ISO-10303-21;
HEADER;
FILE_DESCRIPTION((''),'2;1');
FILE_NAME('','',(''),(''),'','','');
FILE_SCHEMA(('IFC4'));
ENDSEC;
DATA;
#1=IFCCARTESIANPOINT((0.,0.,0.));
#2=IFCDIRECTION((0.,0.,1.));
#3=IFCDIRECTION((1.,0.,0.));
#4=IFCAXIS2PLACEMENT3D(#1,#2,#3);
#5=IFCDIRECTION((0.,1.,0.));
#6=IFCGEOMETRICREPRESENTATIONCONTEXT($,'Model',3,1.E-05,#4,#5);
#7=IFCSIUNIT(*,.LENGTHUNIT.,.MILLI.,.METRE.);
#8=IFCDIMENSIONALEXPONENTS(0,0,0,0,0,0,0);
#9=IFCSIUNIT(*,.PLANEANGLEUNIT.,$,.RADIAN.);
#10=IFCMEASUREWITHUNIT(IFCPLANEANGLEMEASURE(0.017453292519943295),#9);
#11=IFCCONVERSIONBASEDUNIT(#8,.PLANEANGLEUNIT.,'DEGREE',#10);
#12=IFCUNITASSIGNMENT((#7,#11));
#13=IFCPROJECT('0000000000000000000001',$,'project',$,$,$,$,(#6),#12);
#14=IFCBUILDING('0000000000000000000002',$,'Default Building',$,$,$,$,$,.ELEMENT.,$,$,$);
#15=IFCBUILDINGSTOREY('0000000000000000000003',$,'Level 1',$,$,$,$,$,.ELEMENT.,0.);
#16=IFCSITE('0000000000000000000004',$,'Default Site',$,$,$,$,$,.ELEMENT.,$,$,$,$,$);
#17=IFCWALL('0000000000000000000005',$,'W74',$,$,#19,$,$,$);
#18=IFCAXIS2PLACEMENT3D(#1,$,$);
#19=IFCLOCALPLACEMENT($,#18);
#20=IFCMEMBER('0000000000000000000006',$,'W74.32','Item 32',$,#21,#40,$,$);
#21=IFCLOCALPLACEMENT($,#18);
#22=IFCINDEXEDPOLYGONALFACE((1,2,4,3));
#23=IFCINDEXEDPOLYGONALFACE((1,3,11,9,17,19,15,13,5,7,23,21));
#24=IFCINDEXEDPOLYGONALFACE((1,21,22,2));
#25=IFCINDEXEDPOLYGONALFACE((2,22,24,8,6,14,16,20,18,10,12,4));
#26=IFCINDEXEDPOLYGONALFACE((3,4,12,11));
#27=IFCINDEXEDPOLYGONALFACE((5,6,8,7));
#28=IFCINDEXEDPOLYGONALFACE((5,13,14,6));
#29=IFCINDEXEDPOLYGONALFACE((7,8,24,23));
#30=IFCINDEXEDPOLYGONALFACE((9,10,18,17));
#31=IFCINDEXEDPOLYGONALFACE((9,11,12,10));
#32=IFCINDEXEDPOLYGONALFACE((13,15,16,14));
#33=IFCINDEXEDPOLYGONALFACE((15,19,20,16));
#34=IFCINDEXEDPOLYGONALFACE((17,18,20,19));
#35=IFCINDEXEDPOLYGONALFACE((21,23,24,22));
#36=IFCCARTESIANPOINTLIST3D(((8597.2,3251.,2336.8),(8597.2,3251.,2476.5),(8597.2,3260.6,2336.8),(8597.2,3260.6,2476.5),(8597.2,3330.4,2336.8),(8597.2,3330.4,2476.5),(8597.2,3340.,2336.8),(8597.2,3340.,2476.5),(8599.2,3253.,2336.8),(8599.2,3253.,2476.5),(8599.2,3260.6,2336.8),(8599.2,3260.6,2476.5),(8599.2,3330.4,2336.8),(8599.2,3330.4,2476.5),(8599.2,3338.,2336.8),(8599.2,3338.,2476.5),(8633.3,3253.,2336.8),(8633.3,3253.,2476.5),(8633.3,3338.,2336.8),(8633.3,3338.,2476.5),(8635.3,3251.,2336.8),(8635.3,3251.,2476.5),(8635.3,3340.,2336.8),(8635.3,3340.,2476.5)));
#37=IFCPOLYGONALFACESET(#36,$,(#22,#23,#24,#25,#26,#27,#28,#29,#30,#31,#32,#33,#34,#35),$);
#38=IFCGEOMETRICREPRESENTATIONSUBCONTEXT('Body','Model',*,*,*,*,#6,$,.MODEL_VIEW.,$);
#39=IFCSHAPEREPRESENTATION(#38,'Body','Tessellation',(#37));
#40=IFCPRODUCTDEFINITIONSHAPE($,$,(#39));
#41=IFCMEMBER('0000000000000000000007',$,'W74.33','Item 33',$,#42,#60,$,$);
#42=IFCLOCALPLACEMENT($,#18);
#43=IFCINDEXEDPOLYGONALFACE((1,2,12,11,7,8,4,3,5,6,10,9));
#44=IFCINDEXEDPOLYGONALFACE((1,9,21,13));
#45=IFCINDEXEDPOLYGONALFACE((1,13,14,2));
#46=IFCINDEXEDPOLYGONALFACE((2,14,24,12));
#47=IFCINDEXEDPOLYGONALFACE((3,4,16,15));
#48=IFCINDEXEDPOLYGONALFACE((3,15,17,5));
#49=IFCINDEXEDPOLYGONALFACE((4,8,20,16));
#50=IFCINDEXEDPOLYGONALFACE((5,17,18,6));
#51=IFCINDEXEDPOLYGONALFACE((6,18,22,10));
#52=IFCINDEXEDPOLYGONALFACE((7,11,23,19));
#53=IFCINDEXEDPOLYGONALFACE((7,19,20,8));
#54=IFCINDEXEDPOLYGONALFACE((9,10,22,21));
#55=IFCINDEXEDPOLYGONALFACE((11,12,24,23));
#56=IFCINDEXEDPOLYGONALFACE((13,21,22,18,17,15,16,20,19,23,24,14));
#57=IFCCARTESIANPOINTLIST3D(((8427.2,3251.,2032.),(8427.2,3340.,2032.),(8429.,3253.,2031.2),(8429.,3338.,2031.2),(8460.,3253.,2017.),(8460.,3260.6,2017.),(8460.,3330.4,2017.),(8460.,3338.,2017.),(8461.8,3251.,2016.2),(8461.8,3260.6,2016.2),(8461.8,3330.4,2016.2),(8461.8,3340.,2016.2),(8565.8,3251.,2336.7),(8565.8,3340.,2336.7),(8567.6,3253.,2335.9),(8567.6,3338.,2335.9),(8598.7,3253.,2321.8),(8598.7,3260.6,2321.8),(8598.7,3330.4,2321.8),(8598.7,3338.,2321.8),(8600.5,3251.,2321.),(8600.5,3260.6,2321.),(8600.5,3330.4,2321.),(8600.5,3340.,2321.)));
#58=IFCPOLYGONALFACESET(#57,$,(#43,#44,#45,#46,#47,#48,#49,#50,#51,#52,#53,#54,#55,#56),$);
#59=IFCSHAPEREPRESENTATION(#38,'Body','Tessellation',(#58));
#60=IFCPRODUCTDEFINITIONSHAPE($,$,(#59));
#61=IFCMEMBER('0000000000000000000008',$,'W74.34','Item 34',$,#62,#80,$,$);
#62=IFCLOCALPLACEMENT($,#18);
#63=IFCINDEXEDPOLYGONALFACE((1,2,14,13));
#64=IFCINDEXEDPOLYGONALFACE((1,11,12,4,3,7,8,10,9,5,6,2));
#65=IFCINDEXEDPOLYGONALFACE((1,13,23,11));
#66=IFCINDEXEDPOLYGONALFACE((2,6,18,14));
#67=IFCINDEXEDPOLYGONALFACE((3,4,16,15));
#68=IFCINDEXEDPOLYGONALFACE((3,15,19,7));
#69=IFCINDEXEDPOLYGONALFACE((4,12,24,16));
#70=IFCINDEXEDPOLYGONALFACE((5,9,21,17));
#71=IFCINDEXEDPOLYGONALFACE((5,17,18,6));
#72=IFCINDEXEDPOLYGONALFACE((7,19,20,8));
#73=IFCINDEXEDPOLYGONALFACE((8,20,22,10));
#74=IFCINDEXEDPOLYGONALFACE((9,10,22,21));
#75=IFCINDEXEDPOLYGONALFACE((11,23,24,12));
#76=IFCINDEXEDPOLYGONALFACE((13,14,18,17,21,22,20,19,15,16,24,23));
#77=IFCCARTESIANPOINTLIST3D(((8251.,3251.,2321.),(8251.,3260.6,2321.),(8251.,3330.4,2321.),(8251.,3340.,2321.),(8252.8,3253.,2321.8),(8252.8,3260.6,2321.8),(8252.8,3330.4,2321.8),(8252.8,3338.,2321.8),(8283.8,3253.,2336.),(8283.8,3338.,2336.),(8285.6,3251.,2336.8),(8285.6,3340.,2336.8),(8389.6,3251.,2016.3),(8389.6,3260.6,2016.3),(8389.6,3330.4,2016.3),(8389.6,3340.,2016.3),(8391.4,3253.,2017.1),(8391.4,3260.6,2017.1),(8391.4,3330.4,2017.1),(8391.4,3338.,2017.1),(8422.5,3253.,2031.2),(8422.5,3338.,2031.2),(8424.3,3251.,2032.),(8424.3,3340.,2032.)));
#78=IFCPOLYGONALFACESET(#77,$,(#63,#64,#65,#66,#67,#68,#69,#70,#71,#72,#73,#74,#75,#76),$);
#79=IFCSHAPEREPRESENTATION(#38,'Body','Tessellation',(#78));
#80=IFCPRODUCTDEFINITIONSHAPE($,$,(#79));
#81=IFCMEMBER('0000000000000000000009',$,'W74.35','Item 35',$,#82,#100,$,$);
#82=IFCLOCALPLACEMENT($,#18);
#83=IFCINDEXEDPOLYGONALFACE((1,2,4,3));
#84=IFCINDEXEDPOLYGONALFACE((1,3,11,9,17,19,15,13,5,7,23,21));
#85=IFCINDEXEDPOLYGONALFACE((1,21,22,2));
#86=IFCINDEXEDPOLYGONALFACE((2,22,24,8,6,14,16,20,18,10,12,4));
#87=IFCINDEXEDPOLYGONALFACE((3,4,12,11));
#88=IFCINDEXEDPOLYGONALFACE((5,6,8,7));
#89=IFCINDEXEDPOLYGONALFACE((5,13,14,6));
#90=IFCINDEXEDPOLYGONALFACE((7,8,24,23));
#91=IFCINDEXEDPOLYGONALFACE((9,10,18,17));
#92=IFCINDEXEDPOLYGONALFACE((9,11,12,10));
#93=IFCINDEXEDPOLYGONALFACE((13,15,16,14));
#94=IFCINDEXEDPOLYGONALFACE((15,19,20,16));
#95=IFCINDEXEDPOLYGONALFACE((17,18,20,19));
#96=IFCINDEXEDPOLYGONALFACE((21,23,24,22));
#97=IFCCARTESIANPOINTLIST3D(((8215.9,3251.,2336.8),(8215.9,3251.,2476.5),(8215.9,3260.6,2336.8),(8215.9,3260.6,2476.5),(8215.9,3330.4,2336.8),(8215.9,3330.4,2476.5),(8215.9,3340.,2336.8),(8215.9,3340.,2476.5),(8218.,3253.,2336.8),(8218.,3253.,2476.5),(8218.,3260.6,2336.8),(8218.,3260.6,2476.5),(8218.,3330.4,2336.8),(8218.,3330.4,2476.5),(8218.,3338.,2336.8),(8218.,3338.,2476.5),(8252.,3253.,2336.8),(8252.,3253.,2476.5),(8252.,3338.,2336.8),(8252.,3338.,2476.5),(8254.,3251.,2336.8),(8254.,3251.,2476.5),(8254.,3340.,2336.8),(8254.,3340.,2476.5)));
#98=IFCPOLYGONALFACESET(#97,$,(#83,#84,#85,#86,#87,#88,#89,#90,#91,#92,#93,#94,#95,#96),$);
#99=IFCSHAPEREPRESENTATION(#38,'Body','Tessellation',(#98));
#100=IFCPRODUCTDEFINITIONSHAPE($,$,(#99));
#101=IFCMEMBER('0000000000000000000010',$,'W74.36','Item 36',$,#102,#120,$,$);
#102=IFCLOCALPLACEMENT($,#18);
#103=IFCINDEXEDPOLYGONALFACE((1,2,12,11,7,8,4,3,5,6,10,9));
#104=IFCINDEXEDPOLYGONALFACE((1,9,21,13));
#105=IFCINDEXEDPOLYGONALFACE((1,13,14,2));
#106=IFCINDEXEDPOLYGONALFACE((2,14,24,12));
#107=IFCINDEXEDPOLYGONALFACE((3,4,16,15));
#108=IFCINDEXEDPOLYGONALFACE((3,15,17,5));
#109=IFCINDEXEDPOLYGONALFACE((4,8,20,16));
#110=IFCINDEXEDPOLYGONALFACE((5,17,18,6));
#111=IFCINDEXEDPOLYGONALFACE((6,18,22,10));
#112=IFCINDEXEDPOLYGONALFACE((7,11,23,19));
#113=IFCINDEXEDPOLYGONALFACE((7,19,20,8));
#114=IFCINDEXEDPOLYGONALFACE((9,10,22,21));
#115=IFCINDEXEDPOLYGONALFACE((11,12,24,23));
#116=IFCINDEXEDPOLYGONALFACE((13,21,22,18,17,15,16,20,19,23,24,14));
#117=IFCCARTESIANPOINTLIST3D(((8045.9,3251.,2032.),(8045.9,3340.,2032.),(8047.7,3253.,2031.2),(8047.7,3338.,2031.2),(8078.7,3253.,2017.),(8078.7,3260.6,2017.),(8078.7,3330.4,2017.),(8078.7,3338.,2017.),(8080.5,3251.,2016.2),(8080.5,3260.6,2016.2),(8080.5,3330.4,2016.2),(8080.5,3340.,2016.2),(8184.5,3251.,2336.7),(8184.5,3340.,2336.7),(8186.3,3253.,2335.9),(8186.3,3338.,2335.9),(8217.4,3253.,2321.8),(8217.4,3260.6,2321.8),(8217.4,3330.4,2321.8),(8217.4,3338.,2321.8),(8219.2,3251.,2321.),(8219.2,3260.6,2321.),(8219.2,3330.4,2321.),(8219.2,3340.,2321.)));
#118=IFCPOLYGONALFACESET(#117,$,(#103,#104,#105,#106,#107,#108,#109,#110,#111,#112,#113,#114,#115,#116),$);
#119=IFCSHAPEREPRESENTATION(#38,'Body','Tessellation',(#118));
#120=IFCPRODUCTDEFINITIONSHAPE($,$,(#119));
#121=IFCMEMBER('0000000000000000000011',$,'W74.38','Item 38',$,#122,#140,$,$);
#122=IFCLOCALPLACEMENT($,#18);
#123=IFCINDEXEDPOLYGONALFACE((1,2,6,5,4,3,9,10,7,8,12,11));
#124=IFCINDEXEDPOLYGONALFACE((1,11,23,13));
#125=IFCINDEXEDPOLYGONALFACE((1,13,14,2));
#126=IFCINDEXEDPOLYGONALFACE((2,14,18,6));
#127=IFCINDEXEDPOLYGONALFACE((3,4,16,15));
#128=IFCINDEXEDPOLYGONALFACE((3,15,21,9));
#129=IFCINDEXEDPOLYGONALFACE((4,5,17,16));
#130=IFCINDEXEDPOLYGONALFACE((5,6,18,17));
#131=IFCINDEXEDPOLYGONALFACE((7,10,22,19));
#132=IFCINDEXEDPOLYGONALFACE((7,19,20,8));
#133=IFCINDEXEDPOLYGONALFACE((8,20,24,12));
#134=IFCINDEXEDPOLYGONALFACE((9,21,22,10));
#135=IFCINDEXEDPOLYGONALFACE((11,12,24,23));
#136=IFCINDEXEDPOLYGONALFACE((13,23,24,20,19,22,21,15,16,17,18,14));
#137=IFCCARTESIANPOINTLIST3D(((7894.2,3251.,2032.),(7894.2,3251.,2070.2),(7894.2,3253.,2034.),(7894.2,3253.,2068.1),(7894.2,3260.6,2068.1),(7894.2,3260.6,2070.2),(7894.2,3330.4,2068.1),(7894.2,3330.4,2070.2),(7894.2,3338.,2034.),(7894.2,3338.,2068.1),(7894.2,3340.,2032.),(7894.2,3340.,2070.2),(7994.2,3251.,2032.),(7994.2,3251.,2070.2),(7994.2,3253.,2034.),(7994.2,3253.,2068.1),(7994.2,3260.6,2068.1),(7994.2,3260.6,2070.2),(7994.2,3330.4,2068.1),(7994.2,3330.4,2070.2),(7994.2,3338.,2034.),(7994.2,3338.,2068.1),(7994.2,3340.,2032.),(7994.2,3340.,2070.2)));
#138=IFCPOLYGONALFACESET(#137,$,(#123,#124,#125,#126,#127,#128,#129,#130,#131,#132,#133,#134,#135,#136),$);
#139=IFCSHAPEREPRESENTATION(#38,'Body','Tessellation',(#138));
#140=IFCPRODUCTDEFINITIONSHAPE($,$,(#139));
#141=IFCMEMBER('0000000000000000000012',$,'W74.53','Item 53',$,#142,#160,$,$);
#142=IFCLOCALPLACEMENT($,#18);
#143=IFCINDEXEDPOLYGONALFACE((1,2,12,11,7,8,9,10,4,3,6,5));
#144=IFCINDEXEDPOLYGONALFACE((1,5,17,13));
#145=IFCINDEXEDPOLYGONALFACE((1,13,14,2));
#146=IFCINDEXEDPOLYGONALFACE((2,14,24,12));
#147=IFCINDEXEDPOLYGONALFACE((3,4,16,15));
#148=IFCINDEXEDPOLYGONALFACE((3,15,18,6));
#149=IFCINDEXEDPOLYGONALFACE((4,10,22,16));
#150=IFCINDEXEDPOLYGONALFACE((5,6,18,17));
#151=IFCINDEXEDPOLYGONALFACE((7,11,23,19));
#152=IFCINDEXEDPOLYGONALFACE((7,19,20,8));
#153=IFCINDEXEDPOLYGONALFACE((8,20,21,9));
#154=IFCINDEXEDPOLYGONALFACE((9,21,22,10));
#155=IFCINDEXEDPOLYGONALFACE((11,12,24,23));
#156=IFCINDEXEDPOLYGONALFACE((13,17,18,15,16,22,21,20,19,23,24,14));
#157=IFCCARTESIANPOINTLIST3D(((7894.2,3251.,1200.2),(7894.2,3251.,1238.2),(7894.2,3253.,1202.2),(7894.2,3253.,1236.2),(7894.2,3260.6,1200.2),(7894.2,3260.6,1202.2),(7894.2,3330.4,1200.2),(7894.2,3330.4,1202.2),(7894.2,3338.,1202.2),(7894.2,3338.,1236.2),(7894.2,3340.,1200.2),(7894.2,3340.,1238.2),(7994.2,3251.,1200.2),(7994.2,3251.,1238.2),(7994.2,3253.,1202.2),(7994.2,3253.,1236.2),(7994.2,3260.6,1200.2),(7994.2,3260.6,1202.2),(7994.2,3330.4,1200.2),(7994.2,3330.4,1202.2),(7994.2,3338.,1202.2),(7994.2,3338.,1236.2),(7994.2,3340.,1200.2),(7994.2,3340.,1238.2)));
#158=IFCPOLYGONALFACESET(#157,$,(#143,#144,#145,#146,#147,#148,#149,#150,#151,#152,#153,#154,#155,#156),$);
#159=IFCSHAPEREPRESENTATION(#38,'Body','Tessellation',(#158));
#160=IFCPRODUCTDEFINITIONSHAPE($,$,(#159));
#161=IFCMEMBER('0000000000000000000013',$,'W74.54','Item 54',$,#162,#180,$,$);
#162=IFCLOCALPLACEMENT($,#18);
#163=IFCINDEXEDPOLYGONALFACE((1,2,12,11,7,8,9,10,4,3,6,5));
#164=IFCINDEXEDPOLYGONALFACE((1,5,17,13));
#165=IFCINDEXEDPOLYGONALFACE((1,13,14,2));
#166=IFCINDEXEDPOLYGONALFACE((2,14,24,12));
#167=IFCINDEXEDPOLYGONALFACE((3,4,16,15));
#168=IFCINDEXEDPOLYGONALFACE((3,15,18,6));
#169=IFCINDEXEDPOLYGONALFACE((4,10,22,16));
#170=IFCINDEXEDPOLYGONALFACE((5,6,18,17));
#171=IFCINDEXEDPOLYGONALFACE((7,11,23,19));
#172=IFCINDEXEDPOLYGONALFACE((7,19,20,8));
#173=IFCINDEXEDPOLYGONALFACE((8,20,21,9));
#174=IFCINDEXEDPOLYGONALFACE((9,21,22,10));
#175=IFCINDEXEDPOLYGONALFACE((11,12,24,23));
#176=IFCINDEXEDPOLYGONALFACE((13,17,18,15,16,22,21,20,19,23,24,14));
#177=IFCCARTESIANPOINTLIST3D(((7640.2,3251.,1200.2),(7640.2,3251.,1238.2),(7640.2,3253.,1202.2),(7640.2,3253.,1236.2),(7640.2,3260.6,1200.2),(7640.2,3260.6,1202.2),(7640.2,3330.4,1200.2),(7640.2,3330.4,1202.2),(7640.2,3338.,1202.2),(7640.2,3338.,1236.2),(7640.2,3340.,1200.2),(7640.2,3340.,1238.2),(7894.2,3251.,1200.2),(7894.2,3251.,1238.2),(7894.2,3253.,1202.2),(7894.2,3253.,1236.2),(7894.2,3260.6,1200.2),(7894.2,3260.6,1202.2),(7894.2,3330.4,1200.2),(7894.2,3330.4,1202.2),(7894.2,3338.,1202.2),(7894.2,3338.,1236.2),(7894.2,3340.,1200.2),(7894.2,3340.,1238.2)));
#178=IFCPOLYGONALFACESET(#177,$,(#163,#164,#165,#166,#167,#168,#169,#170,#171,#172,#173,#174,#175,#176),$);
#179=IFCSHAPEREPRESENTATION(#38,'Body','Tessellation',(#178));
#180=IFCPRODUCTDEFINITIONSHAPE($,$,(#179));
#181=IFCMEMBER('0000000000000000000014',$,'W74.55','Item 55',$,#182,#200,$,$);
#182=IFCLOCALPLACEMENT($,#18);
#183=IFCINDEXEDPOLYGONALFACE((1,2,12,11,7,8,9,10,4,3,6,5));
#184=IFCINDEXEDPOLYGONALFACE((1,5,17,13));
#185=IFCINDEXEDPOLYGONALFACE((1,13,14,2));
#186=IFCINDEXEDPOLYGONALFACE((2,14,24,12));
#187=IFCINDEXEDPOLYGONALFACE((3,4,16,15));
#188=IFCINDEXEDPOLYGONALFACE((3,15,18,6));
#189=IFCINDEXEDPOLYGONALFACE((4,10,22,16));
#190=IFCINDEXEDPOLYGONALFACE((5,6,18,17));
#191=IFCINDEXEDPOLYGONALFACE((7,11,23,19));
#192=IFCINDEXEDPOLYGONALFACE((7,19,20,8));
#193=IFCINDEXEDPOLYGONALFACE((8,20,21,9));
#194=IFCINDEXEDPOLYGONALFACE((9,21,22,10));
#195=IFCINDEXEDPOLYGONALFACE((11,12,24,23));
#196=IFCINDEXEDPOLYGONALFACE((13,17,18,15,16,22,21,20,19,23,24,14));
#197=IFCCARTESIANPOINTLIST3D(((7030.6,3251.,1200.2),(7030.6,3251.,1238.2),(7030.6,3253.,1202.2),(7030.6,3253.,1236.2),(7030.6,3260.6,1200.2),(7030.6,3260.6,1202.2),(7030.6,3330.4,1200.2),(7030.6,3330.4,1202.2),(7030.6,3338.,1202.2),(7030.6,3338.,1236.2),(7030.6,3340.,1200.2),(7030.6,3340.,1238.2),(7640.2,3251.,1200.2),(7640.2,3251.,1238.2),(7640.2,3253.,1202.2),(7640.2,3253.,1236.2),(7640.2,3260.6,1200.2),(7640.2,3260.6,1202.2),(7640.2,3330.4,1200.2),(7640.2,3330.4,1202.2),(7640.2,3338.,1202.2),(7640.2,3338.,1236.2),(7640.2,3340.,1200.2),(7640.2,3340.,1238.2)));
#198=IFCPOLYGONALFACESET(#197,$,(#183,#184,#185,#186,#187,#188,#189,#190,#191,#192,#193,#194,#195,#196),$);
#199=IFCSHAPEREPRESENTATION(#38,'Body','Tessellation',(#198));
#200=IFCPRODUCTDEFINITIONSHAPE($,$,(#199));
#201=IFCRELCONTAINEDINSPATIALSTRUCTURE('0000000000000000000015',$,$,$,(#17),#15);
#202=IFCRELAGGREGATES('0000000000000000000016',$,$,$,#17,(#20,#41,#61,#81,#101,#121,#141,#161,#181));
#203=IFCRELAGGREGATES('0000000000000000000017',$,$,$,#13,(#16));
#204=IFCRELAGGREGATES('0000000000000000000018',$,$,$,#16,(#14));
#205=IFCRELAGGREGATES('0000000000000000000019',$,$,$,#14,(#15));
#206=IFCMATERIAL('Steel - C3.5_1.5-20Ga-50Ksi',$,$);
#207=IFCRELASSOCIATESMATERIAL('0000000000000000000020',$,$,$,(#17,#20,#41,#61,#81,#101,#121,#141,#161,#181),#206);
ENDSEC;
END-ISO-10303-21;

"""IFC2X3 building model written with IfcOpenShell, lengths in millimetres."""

from ifc_helpers import new_model, entity, si_unit, converted_unit, direction, frame, origin, origin_with_axes, origin_2d_with_axis, place, context, subcontext, project, spatial, c_section, extrude, material, element, aggregate, save


model = new_model("IFC2X3")

# Units and contexts
model_context = context("Model", 3, precision=1e-05, world=origin_with_axes(), true_north=direction((0.0, 1.0, 0.0)))
body_context = subcontext(model_context, "Body", "Model", "MODEL_VIEW")
ifc_project = project(units=[si_unit("LENGTHUNIT", "METRE", prefix="MILLI"), converted_unit("PLANEANGLEUNIT", "DEGREE", entity("IfcPlaneAngleMeasure", 0.017453292519943295), si_unit("PLANEANGLEUNIT", "RADIAN"), dimensions=[0, 0, 0, 0, 0, 0, 0])], contexts=[model_context])

# Site, building, storey
site = spatial("IfcSite", under=ifc_project, Name="Default Site", CompositionType="ELEMENT")
building = spatial("IfcBuilding", under=site, Name="Default Building", CompositionType="ELEMENT")
storey = spatial("IfcBuildingStorey", under=building, Name="Level 1", CompositionType="ELEMENT", Elevation=0.0)

# Wall, members
ifc_material_1 = material(Name="Steel - C3.5_1.5-20Ga-50Ksi")
wall = element("IfcWall", 1, inside=storey, material=ifc_material_1, Name="W74")
member_1_placement = place(None, frame((8616.3, 3295.5, 2476.5), z_axis=(0.0, 0.0, -1.0), x_axis=(-1.0, 0.0, 0.0)))
member_1 = element("IfcMember", 2, at=member_1_placement, material=ifc_material_1, Name="W74.32", Description="Item 32", context=body_context, shape_type="SweptSolid", body=[
    extrude(c_section(Depth=88.9, Width=38.1, WallThickness=2.0, Girth=9.5, at=origin_2d_with_axis()), origin(), (0.0, 0.0, 1.0), 139.7),
])
member_2_placement = place(None, frame((8444.5, 3295.5, 2024.1), z_axis=(0.414, 0.0, 0.91), x_axis=(0.91, 0.0, -0.414)))
member_2 = element("IfcMember", 3, at=member_2_placement, material=ifc_material_1, Name="W74.33", Description="Item 33", context=body_context, shape_type="SweptSolid", body=[
    extrude(c_section(Depth=88.9, Width=38.1, WallThickness=2.0, Girth=9.5, at=origin_2d_with_axis()), origin(), (0.0, 0.0, 1.0), 334.8),
])
member_3_placement = place(None, frame((8268.3, 3295.5, 2328.9), z_axis=(0.414, 0.0, -0.91), x_axis=(-0.91, 0.0, -0.414)))
member_3 = element("IfcMember", 4, at=member_3_placement, material=ifc_material_1, Name="W74.34", Description="Item 34", context=body_context, shape_type="SweptSolid", body=[
    extrude(c_section(Depth=88.9, Width=38.1, WallThickness=2.0, Girth=9.5, at=origin_2d_with_axis()), origin(), (0.0, 0.0, 1.0), 334.8),
])
member_4_placement = place(None, frame((8235.0, 3295.5, 2476.5), z_axis=(0.0, 0.0, -1.0), x_axis=(-1.0, 0.0, 0.0)))
member_4 = element("IfcMember", 5, at=member_4_placement, material=ifc_material_1, Name="W74.35", Description="Item 35", context=body_context, shape_type="SweptSolid", body=[
    extrude(c_section(Depth=88.9, Width=38.1, WallThickness=2.0, Girth=9.5, at=origin_2d_with_axis()), origin(), (0.0, 0.0, 1.0), 139.7),
])
member_5_placement = place(None, frame((8063.2, 3295.5, 2024.1), z_axis=(0.414, 0.0, 0.91), x_axis=(0.91, 0.0, -0.414)))
member_5 = element("IfcMember", 6, at=member_5_placement, material=ifc_material_1, Name="W74.36", Description="Item 36", context=body_context, shape_type="SweptSolid", body=[
    extrude(c_section(Depth=88.9, Width=38.1, WallThickness=2.0, Girth=9.5, at=origin_2d_with_axis()), origin(), (0.0, 0.0, 1.0), 334.8),
])
member_6_placement = place(None, frame((7994.2, 3295.5, 2051.1), z_axis=(-1.0, 0.0, 0.0), x_axis=(0.0, 0.0, 1.0)))
member_6 = element("IfcMember", 7, at=member_6_placement, material=ifc_material_1, Name="W74.38", Description="Item 38", context=body_context, shape_type="SweptSolid", body=[
    extrude(c_section(Depth=88.9, Width=38.1, WallThickness=2.0, Girth=9.5, at=origin_2d_with_axis()), origin(), (0.0, 0.0, 1.0), 100.0),
])
member_7_placement = place(None, frame((7894.2, 3295.5, 1219.2), z_axis=(1.0, 0.0, 0.0), x_axis=(0.0, 0.0, -1.0)))
member_7 = element("IfcMember", 8, at=member_7_placement, material=ifc_material_1, Name="W74.53", Description="Item 53", context=body_context, shape_type="SweptSolid", body=[
    extrude(c_section(Depth=88.9, Width=38.1, WallThickness=2.0, Girth=9.5, at=origin_2d_with_axis()), origin(), (0.0, 0.0, 1.0), 100.0),
])
member_8_placement = place(None, frame((7640.2, 3295.5, 1219.2), z_axis=(1.0, 0.0, 0.0), x_axis=(0.0, 0.0, -1.0)))
member_8 = element("IfcMember", 9, at=member_8_placement, material=ifc_material_1, Name="W74.54", Description="Item 54", context=body_context, shape_type="SweptSolid", body=[
    extrude(c_section(Depth=88.9, Width=38.1, WallThickness=2.0, Girth=9.5, at=origin_2d_with_axis()), origin(), (0.0, 0.0, 1.0), 254.0),
])
member_9_placement = place(None, frame((7030.6, 3295.5, 1219.2), z_axis=(1.0, 0.0, 0.0), x_axis=(0.0, 0.0, -1.0)))
member_9 = element("IfcMember", 10, at=member_9_placement, material=ifc_material_1, Name="W74.55", Description="Item 55", context=body_context, shape_type="SweptSolid", body=[
    extrude(c_section(Depth=88.9, Width=38.1, WallThickness=2.0, Girth=9.5, at=origin_2d_with_axis()), origin(), (0.0, 0.0, 1.0), 609.6),
])
aggregate(wall, [member_1, member_2, member_3, member_4, member_5, member_6, member_7, member_8, member_9])

save(model, "model.ifc")
